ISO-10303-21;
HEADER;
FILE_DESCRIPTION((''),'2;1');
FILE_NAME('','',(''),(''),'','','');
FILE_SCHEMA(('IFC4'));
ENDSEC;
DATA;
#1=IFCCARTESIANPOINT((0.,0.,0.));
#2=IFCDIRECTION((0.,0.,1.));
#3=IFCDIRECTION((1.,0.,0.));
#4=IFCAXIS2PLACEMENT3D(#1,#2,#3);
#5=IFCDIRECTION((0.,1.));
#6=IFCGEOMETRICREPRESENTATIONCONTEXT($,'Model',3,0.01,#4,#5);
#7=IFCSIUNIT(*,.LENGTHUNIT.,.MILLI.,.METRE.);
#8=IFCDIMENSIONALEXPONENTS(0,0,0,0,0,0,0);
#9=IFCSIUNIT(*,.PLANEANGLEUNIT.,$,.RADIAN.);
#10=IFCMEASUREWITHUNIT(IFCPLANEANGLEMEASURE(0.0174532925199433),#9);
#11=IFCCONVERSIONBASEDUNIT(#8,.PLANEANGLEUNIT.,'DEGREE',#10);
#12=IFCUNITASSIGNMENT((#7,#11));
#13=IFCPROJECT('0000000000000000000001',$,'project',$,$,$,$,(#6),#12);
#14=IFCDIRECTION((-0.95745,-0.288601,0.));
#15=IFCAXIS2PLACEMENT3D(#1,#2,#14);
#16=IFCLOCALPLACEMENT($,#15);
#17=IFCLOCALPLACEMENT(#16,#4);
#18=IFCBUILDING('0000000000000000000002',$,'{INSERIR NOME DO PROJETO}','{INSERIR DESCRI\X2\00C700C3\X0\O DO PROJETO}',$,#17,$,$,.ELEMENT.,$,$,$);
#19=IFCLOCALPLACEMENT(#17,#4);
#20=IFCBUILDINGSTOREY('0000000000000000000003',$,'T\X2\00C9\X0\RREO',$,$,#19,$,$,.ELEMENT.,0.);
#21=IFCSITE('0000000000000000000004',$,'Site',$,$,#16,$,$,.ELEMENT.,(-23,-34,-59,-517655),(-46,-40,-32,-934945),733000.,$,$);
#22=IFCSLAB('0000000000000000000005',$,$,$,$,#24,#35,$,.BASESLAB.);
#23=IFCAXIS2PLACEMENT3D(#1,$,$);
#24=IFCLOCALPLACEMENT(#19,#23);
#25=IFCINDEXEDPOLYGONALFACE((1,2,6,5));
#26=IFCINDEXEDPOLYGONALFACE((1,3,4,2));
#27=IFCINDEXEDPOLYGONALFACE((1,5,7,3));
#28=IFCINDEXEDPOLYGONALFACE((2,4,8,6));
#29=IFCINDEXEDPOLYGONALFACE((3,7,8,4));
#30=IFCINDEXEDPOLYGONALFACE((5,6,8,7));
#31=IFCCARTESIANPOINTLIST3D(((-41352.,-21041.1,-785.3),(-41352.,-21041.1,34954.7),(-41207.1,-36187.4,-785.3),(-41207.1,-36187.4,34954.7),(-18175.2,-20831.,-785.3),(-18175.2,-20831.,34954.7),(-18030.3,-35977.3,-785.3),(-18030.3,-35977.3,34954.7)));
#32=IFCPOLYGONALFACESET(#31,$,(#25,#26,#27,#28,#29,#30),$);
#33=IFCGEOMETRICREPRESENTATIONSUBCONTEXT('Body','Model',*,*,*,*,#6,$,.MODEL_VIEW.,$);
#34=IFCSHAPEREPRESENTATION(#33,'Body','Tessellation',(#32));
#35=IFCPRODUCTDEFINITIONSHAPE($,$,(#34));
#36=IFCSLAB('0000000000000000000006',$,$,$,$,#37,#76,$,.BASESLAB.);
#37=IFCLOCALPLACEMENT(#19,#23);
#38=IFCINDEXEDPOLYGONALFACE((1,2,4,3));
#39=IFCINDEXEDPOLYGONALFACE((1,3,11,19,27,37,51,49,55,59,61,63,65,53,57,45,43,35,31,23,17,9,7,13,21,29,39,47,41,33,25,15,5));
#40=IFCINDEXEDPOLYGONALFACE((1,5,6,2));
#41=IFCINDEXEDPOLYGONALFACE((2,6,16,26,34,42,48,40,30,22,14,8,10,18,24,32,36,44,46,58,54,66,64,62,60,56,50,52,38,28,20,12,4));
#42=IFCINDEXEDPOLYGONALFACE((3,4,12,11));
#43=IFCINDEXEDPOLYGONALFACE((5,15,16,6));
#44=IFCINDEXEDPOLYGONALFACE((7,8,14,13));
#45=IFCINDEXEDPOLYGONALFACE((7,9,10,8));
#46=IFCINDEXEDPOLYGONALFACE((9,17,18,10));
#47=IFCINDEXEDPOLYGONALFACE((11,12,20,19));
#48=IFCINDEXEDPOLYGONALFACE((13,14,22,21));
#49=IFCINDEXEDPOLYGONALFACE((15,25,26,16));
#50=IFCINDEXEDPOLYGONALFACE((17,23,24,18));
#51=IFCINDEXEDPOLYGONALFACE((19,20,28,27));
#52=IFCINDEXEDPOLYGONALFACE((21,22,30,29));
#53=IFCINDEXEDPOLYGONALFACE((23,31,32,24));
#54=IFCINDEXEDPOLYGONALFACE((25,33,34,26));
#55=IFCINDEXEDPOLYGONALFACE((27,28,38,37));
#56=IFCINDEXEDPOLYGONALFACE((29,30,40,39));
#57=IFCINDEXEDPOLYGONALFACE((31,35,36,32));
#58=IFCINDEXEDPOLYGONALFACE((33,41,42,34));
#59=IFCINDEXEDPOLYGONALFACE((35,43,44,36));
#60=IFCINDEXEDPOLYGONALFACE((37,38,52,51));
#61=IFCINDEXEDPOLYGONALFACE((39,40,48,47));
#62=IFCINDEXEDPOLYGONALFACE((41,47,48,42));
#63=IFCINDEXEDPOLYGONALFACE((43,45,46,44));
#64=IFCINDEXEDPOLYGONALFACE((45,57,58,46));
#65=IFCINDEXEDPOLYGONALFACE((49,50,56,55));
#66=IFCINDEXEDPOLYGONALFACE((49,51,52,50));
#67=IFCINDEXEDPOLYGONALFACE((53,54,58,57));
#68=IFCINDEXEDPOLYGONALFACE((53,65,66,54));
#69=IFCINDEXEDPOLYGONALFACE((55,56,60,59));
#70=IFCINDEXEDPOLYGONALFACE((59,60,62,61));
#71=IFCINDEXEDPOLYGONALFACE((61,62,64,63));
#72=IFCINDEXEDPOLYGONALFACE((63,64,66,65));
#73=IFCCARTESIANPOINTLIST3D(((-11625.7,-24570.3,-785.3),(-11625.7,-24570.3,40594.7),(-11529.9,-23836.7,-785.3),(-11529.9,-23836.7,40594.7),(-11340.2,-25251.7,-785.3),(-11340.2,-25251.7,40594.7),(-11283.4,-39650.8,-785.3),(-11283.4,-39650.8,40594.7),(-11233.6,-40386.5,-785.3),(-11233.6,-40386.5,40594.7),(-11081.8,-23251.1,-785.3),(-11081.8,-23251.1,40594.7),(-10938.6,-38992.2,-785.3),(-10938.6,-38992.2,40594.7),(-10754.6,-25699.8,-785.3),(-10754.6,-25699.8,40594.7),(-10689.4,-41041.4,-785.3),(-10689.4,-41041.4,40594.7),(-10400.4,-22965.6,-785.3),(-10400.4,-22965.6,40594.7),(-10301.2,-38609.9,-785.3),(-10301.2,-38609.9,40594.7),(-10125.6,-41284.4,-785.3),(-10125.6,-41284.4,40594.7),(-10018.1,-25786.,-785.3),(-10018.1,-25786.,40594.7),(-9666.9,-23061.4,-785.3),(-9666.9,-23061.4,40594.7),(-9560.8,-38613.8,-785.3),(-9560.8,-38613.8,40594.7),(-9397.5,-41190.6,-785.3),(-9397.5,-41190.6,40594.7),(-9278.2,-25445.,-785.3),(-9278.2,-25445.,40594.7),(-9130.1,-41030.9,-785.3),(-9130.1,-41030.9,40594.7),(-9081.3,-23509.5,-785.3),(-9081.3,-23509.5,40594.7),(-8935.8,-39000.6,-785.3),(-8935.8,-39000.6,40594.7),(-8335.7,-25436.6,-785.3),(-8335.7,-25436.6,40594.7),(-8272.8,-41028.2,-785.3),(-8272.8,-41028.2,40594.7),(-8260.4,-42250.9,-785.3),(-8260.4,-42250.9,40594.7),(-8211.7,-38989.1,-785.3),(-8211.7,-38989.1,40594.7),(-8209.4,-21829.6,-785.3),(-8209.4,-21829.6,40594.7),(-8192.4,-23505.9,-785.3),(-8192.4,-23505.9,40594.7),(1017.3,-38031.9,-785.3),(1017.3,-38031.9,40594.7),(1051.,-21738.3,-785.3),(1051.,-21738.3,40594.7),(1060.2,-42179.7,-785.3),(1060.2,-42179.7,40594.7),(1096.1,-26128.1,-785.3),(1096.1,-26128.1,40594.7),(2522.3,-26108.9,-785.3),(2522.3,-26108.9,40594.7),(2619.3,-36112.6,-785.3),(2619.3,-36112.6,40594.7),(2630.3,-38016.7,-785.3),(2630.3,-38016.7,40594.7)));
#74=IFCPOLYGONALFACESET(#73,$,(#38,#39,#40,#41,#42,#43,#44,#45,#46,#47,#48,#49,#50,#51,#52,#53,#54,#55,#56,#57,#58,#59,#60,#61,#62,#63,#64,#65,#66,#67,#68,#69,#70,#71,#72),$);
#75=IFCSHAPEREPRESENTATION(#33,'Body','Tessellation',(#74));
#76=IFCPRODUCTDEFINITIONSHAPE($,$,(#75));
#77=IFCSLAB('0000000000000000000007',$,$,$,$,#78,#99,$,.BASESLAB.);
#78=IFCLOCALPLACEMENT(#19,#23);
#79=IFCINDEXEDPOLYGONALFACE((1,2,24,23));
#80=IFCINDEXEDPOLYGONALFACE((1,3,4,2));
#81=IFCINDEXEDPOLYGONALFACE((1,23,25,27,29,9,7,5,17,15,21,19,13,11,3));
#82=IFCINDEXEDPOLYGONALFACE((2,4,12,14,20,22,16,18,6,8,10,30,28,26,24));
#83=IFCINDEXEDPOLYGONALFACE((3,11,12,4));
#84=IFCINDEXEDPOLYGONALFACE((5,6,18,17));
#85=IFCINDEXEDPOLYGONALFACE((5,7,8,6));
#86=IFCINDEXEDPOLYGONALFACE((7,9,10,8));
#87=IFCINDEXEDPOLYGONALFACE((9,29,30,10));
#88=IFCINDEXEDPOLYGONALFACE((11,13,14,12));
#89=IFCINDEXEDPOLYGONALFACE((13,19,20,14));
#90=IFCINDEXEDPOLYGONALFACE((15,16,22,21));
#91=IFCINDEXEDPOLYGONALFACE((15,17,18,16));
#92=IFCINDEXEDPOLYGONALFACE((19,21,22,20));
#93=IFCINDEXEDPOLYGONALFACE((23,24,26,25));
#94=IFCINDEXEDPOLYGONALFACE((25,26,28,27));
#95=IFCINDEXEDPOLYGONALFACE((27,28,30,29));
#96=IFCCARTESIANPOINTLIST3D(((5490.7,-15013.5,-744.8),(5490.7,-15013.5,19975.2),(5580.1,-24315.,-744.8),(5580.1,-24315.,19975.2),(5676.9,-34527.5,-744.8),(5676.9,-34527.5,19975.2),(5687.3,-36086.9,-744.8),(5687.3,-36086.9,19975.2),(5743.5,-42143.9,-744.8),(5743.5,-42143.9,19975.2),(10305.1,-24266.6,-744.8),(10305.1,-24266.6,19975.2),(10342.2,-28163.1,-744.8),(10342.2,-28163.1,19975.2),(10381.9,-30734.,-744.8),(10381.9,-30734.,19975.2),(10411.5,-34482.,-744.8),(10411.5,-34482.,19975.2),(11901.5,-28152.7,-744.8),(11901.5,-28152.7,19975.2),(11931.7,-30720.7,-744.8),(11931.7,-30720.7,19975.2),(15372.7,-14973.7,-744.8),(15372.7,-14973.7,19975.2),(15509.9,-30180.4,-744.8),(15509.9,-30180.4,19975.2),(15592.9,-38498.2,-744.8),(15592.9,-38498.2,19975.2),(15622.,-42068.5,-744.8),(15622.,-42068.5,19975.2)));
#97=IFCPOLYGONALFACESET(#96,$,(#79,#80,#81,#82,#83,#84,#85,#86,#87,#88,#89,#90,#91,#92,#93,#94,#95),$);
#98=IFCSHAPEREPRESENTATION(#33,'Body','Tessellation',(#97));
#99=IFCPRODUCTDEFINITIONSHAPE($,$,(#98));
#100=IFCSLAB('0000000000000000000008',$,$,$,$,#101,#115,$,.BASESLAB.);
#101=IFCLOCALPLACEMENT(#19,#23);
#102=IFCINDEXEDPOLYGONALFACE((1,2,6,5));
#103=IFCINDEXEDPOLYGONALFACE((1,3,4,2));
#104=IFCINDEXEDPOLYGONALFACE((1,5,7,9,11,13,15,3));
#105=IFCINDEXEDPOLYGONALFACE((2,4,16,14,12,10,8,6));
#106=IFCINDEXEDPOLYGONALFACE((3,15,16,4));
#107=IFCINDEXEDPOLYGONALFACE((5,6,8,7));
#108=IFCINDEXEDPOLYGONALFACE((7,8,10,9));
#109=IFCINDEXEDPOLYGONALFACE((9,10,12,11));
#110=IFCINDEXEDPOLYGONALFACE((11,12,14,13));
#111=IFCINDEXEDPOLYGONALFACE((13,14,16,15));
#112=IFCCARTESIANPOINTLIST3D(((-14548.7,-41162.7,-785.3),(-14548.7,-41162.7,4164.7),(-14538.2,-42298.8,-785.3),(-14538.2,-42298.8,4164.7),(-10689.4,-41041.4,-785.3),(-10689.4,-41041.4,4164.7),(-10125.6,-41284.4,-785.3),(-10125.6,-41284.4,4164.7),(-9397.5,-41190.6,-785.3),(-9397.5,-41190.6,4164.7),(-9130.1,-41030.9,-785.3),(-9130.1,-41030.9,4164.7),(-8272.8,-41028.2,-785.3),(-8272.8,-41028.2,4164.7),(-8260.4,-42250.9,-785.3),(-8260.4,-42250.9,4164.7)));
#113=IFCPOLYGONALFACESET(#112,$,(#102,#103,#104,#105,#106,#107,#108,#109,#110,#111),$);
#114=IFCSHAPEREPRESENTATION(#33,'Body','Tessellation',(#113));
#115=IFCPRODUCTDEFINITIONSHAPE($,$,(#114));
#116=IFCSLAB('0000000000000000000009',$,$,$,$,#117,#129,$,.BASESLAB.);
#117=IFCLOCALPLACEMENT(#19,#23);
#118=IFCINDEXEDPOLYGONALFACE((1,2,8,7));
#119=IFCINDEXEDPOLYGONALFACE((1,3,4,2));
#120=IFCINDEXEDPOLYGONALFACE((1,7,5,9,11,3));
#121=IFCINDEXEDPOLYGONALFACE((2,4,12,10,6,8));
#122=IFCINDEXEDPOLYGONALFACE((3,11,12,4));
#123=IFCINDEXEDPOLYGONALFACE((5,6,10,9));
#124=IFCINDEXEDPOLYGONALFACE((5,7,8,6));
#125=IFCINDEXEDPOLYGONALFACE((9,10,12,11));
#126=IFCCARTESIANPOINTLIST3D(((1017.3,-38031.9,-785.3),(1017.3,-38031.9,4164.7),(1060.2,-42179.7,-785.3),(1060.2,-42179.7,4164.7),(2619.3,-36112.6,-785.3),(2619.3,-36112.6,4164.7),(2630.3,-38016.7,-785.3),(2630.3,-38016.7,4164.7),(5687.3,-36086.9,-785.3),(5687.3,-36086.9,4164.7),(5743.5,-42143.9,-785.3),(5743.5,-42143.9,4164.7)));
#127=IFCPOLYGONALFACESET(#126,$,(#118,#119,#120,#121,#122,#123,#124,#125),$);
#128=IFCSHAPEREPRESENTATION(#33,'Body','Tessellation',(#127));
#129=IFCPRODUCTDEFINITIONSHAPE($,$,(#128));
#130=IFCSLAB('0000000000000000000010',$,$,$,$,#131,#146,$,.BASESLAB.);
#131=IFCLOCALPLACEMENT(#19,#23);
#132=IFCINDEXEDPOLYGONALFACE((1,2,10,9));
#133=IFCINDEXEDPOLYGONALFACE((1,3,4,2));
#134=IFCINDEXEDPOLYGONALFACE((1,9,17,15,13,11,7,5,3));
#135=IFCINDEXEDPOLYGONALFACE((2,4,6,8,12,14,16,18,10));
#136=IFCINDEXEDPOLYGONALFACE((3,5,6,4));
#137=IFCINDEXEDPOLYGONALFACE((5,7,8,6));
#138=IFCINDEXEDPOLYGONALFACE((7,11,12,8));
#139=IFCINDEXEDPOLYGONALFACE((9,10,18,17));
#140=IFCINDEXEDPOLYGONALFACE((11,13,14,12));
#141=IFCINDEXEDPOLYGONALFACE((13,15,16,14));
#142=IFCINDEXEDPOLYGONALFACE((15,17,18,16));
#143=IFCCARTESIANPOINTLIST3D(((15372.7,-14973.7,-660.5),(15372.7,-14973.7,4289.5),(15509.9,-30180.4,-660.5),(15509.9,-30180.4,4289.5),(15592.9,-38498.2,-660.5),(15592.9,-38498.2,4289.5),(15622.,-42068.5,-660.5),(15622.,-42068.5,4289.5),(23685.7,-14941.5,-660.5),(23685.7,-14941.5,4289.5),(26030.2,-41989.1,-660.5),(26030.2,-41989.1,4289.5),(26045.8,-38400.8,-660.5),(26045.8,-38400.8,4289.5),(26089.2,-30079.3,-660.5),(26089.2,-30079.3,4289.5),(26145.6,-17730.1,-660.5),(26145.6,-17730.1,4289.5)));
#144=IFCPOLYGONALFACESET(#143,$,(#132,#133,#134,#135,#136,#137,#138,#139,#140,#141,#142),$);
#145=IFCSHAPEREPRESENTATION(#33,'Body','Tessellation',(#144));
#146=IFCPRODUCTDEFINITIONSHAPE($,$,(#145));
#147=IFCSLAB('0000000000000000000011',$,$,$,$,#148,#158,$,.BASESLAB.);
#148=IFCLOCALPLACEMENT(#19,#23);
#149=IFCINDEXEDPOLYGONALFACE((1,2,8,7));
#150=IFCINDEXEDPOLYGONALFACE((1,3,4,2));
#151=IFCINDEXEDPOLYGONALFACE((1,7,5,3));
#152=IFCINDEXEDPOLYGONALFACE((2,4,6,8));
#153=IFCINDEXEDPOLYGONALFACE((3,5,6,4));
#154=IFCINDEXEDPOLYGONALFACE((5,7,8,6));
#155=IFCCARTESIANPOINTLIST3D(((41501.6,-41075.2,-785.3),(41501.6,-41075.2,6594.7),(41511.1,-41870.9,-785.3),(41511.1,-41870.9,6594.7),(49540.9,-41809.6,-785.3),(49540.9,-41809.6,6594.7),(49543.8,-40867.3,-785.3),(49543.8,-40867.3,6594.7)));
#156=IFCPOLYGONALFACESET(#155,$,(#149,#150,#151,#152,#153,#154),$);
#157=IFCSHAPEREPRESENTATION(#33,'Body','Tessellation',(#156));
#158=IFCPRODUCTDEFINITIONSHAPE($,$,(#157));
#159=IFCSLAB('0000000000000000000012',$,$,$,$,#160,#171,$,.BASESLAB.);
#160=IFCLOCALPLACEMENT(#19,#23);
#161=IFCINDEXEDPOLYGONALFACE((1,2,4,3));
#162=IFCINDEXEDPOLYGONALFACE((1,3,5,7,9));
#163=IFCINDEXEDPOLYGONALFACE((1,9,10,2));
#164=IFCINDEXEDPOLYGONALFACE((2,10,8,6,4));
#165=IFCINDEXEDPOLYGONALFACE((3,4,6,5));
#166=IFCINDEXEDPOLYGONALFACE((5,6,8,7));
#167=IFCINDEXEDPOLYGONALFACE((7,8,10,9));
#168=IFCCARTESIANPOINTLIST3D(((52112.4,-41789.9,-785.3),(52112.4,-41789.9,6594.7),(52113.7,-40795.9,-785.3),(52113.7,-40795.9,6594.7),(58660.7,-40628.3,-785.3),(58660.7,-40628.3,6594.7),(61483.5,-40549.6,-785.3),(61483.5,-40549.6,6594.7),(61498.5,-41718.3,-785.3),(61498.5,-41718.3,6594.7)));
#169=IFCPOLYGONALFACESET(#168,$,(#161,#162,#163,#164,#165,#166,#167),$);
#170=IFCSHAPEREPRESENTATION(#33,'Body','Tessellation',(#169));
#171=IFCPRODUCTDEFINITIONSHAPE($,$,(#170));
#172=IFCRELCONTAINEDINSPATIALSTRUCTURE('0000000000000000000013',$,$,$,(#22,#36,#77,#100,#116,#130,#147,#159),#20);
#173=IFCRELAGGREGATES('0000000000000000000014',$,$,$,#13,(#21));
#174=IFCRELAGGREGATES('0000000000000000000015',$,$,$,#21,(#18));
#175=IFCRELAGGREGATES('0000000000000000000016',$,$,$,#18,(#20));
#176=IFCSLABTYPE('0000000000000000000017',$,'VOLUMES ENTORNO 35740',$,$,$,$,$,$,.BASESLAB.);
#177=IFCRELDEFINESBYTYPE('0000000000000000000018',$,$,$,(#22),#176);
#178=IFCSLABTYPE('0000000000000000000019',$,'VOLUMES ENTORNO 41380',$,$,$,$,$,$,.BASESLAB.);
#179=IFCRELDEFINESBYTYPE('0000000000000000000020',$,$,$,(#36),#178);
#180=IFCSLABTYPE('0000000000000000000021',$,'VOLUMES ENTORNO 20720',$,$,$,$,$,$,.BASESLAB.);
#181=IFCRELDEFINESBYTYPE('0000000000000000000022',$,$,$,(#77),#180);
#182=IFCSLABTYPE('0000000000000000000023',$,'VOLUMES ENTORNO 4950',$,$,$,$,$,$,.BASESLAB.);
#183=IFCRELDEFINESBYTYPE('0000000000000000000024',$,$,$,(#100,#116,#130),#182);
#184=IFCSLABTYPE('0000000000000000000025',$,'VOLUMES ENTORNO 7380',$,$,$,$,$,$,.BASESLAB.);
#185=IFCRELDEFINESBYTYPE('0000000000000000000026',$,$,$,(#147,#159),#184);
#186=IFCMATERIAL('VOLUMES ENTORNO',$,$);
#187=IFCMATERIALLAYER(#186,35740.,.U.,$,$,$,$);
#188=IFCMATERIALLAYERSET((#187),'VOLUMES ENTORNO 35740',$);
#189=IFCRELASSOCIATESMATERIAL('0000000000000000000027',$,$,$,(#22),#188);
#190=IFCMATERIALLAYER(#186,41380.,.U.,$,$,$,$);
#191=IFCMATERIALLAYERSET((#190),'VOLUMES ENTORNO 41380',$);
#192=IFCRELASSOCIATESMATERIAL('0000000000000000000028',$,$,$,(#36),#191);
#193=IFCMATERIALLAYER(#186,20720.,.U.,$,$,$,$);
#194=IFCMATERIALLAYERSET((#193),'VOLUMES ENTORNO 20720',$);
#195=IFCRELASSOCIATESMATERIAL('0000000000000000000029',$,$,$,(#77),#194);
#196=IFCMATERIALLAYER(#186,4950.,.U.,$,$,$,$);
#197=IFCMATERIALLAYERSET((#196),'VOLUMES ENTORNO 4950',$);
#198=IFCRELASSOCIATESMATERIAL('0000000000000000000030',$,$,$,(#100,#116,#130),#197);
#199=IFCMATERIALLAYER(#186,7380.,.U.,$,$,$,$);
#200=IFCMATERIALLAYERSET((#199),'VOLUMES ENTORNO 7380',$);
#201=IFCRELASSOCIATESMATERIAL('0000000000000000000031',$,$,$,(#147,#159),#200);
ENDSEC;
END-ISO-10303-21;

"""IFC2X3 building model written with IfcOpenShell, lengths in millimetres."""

from ifc_helpers import new_model, entity, si_unit, converted_unit, direction, frame, origin_with_axes, place, context, subcontext, project, spatial, polyline, outline, extrude, material, layer, layer_set, layer_usage, type_object, element, save


model = new_model("IFC2X3")

# Units and contexts
model_context = context("Model", 3, precision=0.01, world=origin_with_axes(), true_north=direction((0.0, 1.0)))
body_context = subcontext(model_context, "Body", "Model", "MODEL_VIEW")
ifc_project = project(units=[si_unit("LENGTHUNIT", "METRE", prefix="MILLI"), converted_unit("PLANEANGLEUNIT", "DEGREE", entity("IfcPlaneAngleMeasure", 0.0174532925199433), si_unit("PLANEANGLEUNIT", "RADIAN"), dimensions=[0, 0, 0, 0, 0, 0, 0])], contexts=[model_context])

# Site, building, storey
site_placement = place(None, frame((0.0, 0.0, 0.0), z_axis=(0.0, 0.0, 1.0), x_axis=(-0.95745, -0.288601, 0.0)))
site = spatial("IfcSite", under=ifc_project, at=site_placement, Name="Site", CompositionType="ELEMENT", RefLatitude=(-23, -34, -59, -517655), RefLongitude=(-46, -40, -32, -934945), RefElevation=733000.0)
building_placement = place(site_placement, origin_with_axes())
building = spatial("IfcBuilding", under=site, at=building_placement, Name="{INSERIR NOME DO PROJETO}", Description="{INSERIR DESCRIÇÃO DO PROJETO}", CompositionType="ELEMENT")
storey_placement = place(building_placement, origin_with_axes())
storey = spatial("IfcBuildingStorey", under=building, at=storey_placement, Name="TÉRREO", CompositionType="ELEMENT", Elevation=0.0)

# Slabs
ifc_material_1 = material(Name="VOLUMES ENTORNO")
ifc_layer_1 = layer(ifc_material_1, 35740.0, ventilated="UNKNOWN")
ifc_layer_set_1 = layer_set([ifc_layer_1], Name="VOLUMES ENTORNO 35740")
ifc_layer_usage_1 = layer_usage(ifc_layer_set_1, "AXIS3", "NEGATIVE", 35740.0)
slab_type_1 = type_object("IfcSlabType", Name="VOLUMES ENTORNO 35740", PredefinedType="BASESLAB")
slab_1_placement = place(storey_placement, frame((-41352.0, -21041.1, -785.3), z_axis=(0.0, 0.0, 1.0), x_axis=(1.0, 0.0, 0.0)))
element("IfcSlab", 1, at=slab_1_placement, inside=storey, type_object=slab_type_1, material=ifc_layer_usage_1, PredefinedType="BASESLAB", context=body_context, shape_type="SweptSolid", body=[
    extrude(outline(polyline([(0.0, 0.0), (144.9, -15146.3), (23321.7, -14936.2), (23176.8, 210.1), (0.0, 0.0)])), origin_with_axes(), (0.0, 0.0, 1.0), 35740.0),
])
ifc_layer_2 = layer(ifc_material_1, 41380.0, ventilated="UNKNOWN")
ifc_layer_set_2 = layer_set([ifc_layer_2], Name="VOLUMES ENTORNO 41380")
ifc_layer_usage_2 = layer_usage(ifc_layer_set_2, "AXIS3", "NEGATIVE", 41380.0)
slab_type_2 = type_object("IfcSlabType", Name="VOLUMES ENTORNO 41380", PredefinedType="BASESLAB")
slab_2_placement = place(storey_placement, frame((1096.1, -26128.1, -785.3), z_axis=(0.0, 0.0, 1.0), x_axis=(1.0, 0.0, 0.0)))
element("IfcSlab", 2, at=slab_2_placement, inside=storey, type_object=slab_type_2, material=ifc_layer_usage_2, PredefinedType="BASESLAB", context=body_context, shape_type="SweptSolid", body=[
    extrude(outline(polyline([(0.0, 0.0), (-45.0, 4389.8), (-9305.4, 4298.5), (-9288.5, 2622.2), (-10177.3, 2618.6), (-10762.9, 3066.7), (-11496.5, 3162.5), (-12177.9, 2877.0), (-12626.0, 2291.4), (-12721.7, 1557.8), (-12436.2, 876.4), (-11850.6, 428.3), (-11114.2, 342.1), (-10374.3, 683.1), (-9431.8, 691.4), (-9307.7, -12861.0), (-10031.9, -12872.5), (-10656.8, -12485.7), (-11397.2, -12481.9), (-12034.7, -12864.2), (-12379.4, -13522.7), (-12329.6, -14258.4), (-11785.5, -14913.3), (-11221.6, -15156.3), (-10493.5, -15062.5), (-10226.1, -14902.9), (-9368.8, -14900.2), (-9356.5, -16122.8), (-35.8, -16051.6), (-78.8, -11903.8), (1534.2, -11888.6), (1523.3, -9984.5), (1426.2, 19.2), (0.0, 0.0)])), origin_with_axes(), (0.0, 0.0, 1.0), 41380.0),
])
ifc_layer_3 = layer(ifc_material_1, 20720.0, ventilated="UNKNOWN")
ifc_layer_set_3 = layer_set([ifc_layer_3], Name="VOLUMES ENTORNO 20720")
ifc_layer_usage_3 = layer_usage(ifc_layer_set_3, "AXIS3", "NEGATIVE", 20720.0)
slab_type_3 = type_object("IfcSlabType", Name="VOLUMES ENTORNO 20720", PredefinedType="BASESLAB")
slab_3_placement = place(storey_placement, frame((10305.1, -24266.6, -744.8), z_axis=(0.0, 0.0, 1.0), x_axis=(1.0, 0.0, 0.0)))
element("IfcSlab", 3, at=slab_3_placement, inside=storey, type_object=slab_type_3, material=ifc_layer_usage_3, PredefinedType="BASESLAB", context=body_context, shape_type="SweptSolid", body=[
    extrude(outline(polyline([(0.0, 0.0), (37.0, -3896.5), (1596.4, -3886.1), (1626.6, -6454.1), (76.8, -6467.3), (106.4, -10215.4), (-4628.2, -10260.9), (-4617.8, -11820.2), (-4561.6, -17877.3), (5316.9, -17801.9), (5287.7, -14231.6), (5204.8, -5913.7), (5067.6, 9292.9), (-4814.4, 9253.2), (-4725.0, -48.4), (0.0, 0.0)])), origin_with_axes(), (0.0, 0.0, 1.0), 20720.0),
])
ifc_layer_4 = layer(ifc_material_1, 4950.0, ventilated="UNKNOWN")
ifc_layer_set_4 = layer_set([ifc_layer_4], Name="VOLUMES ENTORNO 4950")
ifc_layer_usage_4 = layer_usage(ifc_layer_set_4, "AXIS3", "NEGATIVE", 4950.0)
slab_type_4 = type_object("IfcSlabType", Name="VOLUMES ENTORNO 4950", PredefinedType="BASESLAB")
slab_4_placement = place(storey_placement, frame((-8272.8, -41028.2, -785.3), z_axis=(0.0, 0.0, 1.0), x_axis=(1.0, 0.0, 0.0)))
element("IfcSlab", 4, at=slab_4_placement, inside=storey, type_object=slab_type_4, material=ifc_layer_usage_4, PredefinedType="BASESLAB", context=body_context, shape_type="SweptSolid", body=[
    extrude(outline(polyline([(0.0, 0.0), (-857.3, -2.7), (-1124.7, -162.3), (-1852.8, -256.2), (-2416.6, -13.1), (-6275.9, -134.5), (-6265.4, -1270.6), (12.4, -1222.6), (0.0, 0.0)])), origin_with_axes(), (0.0, 0.0, 1.0), 4950.0),
])
ifc_layer_usage_5 = layer_usage(ifc_layer_set_4, "AXIS3", "NEGATIVE", 4950.0)
slab_5_placement = place(storey_placement, frame((2619.3, -36112.6, -785.3), z_axis=(0.0, 0.0, 1.0), x_axis=(1.0, 0.0, 0.0)))
element("IfcSlab", 5, at=slab_5_placement, inside=storey, type_object=slab_type_4, material=ifc_layer_usage_5, PredefinedType="BASESLAB", context=body_context, shape_type="SweptSolid", body=[
    extrude(outline(polyline([(0.0, 0.0), (10.9, -1904.2), (-1602.1, -1919.3), (-1559.1, -6067.2), (3124.1, -6031.4), (3068.0, 25.7), (0.0, 0.0)])), origin_with_axes(), (0.0, 0.0, 1.0), 4950.0),
])
ifc_layer_usage_6 = layer_usage(ifc_layer_set_4, "AXIS3", "NEGATIVE", 4950.0)
slab_6_placement = place(storey_placement, frame((26145.6, -17730.1, -660.5), z_axis=(0.0, 0.0, 1.0), x_axis=(1.0, 0.0, 0.0)))
element("IfcSlab", 6, at=slab_6_placement, inside=storey, type_object=slab_type_4, material=ifc_layer_usage_6, PredefinedType="BASESLAB", context=body_context, shape_type="SweptSolid", body=[
    extrude(outline(polyline([(0.0, 0.0), (-2459.9, 2788.6), (-10772.9, 2756.4), (-10635.7, -12450.3), (-10552.7, -20768.2), (-10523.6, -24338.5), (-115.4, -24259.0), (-99.8, -20670.7), (-56.4, -12349.2), (0.0, 0.0)])), origin_with_axes(), (0.0, 0.0, 1.0), 4950.0),
])
ifc_layer_5 = layer(ifc_material_1, 7380.0, ventilated="UNKNOWN")
ifc_layer_set_5 = layer_set([ifc_layer_5], Name="VOLUMES ENTORNO 7380")
ifc_layer_usage_7 = layer_usage(ifc_layer_set_5, "AXIS3", "NEGATIVE", 7380.0)
slab_type_5 = type_object("IfcSlabType", Name="VOLUMES ENTORNO 7380", PredefinedType="BASESLAB")
slab_7_placement = place(storey_placement, frame((49540.9, -41809.6, -785.3), z_axis=(0.0, 0.0, 1.0), x_axis=(1.0, 0.0, 0.0)))
element("IfcSlab", 7, at=slab_7_placement, inside=storey, type_object=slab_type_5, material=ifc_layer_usage_7, PredefinedType="BASESLAB", context=body_context, shape_type="SweptSolid", body=[
    extrude(outline(polyline([(0.0, 0.0), (2.9, 942.3), (-8039.3, 734.4), (-8029.8, -61.3), (0.0, 0.0)])), origin_with_axes(), (0.0, 0.0, 1.0), 7380.0),
])
ifc_layer_usage_8 = layer_usage(ifc_layer_set_5, "AXIS3", "NEGATIVE", 7380.0)
slab_8_placement = place(storey_placement, frame((61483.5, -40549.6, -785.3), z_axis=(0.0, 0.0, 1.0), x_axis=(1.0, 0.0, 0.0)))
element("IfcSlab", 8, at=slab_8_placement, inside=storey, type_object=slab_type_5, material=ifc_layer_usage_8, PredefinedType="BASESLAB", context=body_context, shape_type="SweptSolid", body=[
    extrude(outline(polyline([(0.0, 0.0), (-2822.8, -78.7), (-9369.8, -246.4), (-9371.1, -1240.3), (15.0, -1168.7), (0.0, 0.0)])), origin_with_axes(), (0.0, 0.0, 1.0), 7380.0),
])

save(model, "model.ifc")
